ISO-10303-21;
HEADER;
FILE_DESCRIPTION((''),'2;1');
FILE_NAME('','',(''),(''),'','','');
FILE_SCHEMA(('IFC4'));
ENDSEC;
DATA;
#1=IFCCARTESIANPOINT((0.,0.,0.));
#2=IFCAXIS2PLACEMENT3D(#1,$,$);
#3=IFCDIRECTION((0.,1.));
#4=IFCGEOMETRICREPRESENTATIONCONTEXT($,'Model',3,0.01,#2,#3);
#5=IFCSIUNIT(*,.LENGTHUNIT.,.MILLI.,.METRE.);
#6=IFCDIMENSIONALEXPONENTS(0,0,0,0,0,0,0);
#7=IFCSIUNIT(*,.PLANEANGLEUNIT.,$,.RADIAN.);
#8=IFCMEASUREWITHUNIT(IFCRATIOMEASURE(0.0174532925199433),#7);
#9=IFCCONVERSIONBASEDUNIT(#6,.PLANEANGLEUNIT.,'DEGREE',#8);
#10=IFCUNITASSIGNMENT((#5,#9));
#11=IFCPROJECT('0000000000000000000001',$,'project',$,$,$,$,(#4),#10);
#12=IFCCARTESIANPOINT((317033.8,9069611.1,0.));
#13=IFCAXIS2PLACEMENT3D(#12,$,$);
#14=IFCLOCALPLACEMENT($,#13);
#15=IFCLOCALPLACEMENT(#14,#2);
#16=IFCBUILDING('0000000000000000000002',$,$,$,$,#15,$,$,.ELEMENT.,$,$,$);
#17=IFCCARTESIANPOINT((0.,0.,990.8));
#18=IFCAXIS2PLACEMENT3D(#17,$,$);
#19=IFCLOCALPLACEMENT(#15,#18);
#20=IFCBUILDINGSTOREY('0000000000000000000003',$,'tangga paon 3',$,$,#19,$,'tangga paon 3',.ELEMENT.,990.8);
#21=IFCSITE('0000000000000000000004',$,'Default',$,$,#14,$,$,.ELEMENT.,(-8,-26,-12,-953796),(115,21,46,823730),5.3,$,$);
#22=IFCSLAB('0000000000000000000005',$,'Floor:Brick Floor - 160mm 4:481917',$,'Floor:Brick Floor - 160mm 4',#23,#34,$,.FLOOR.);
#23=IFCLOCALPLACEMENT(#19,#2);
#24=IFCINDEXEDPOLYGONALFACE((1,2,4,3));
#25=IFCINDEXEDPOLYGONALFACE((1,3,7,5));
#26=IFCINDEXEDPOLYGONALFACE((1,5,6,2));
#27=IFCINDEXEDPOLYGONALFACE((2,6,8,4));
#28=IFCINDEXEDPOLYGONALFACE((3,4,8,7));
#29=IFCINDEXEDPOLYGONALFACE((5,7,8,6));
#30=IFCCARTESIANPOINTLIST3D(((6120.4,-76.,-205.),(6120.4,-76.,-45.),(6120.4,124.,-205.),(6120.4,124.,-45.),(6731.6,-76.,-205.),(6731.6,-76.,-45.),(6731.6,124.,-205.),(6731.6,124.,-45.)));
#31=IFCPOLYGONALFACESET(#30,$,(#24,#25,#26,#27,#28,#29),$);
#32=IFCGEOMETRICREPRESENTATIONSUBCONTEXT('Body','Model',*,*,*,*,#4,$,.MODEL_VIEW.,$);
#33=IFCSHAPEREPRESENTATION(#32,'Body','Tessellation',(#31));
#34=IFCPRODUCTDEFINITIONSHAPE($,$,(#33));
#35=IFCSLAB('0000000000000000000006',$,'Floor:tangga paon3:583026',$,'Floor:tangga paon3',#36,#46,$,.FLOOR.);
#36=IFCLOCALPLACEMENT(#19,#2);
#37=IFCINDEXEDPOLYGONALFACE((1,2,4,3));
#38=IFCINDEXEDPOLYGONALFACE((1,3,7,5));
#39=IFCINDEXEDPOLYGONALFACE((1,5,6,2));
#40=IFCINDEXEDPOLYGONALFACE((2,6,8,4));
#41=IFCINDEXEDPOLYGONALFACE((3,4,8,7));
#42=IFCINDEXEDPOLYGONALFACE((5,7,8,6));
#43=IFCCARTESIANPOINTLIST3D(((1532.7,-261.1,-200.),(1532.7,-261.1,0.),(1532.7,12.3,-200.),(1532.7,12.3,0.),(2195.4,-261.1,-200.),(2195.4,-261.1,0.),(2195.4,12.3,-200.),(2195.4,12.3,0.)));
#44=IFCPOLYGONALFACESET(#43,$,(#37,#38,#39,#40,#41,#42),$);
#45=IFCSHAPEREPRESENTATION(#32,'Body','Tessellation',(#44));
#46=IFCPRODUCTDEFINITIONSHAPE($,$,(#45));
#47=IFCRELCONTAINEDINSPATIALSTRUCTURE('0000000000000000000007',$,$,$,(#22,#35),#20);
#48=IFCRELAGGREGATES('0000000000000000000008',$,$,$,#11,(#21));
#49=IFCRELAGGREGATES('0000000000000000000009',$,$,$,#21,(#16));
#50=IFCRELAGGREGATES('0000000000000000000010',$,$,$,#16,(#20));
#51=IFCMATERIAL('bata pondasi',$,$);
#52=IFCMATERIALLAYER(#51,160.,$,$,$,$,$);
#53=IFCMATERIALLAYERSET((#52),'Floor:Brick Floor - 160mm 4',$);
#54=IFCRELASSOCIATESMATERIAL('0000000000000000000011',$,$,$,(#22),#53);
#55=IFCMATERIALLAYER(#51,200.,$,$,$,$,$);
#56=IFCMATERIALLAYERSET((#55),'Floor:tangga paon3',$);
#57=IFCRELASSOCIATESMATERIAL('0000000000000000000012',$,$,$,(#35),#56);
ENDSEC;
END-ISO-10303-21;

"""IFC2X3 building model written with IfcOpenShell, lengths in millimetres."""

from ifc_helpers import new_model, entity, si_unit, converted_unit, direction, frame, frame_2d, origin, origin_2d_with_axis, place, context, subcontext, project, spatial, rectangle, extrude, material, layer, layer_set, layer_usage, element, save


model = new_model("IFC2X3")

# Units and contexts
model_context = context("Model", 3, precision=0.01, world=origin(), true_north=direction((0.0, 1.0)))
body_context = subcontext(model_context, "Body", "Model", "MODEL_VIEW")
ifc_project = project(units=[si_unit("LENGTHUNIT", "METRE", prefix="MILLI"), converted_unit("PLANEANGLEUNIT", "DEGREE", entity("IfcRatioMeasure", 0.0174532925199433), si_unit("PLANEANGLEUNIT", "RADIAN"), dimensions=[0, 0, 0, 0, 0, 0, 0])], contexts=[model_context])

# Site, building, storey
site_placement = place(None, frame((317033.8, 9069611.1, 0.0)))
site = spatial("IfcSite", under=ifc_project, at=site_placement, Name="Default", CompositionType="ELEMENT", RefLatitude=(-8, -26, -12, -953796), RefLongitude=(115, 21, 46, 823730), RefElevation=5.3)
building_placement = place(site_placement, origin())
building = spatial("IfcBuilding", under=site, at=building_placement, CompositionType="ELEMENT")
storey_placement = place(building_placement, frame((0.0, 0.0, 990.8)))
storey = spatial("IfcBuildingStorey", under=building, at=storey_placement, Name="tangga paon 3", LongName="tangga paon 3", CompositionType="ELEMENT", Elevation=990.8)

# Slabs
ifc_material = material(Name="bata pondasi")
ifc_layer_1 = layer(ifc_material, 160.0)
ifc_layer_set_1 = layer_set([ifc_layer_1], Name="Floor:Brick Floor - 160mm 4")
ifc_layer_usage_1 = layer_usage(ifc_layer_set_1, "AXIS3", "POSITIVE", 0.0)
slab_1_placement = place(storey_placement, origin())
element("IfcSlab", 1, at=slab_1_placement, inside=storey, material=ifc_layer_usage_1, Name="Floor:Brick Floor - 160mm 4:481917", ObjectType="Floor:Brick Floor - 160mm 4", PredefinedType="FLOOR", context=body_context, shape_type="SweptSolid", body=[
    extrude(rectangle(XDim=200.0, YDim=611.2, at=frame_2d((0.0, 0.0), x_axis=(1.0, 0.0))), frame((6426.0, 24.0, -45.0), z_axis=(0.0, 0.0, -1.0), x_axis=(0.0, 1.0, 0.0)), (0.0, 0.0, 1.0), 160.0),
])
ifc_layer_2 = layer(ifc_material, 200.0)
ifc_layer_set_2 = layer_set([ifc_layer_2], Name="Floor:tangga paon3")
ifc_layer_usage_2 = layer_usage(ifc_layer_set_2, "AXIS3", "POSITIVE", 0.0)
slab_2_placement = place(storey_placement, origin())
element("IfcSlab", 2, at=slab_2_placement, inside=storey, material=ifc_layer_usage_2, Name="Floor:tangga paon3:583026", ObjectType="Floor:tangga paon3", PredefinedType="FLOOR", context=body_context, shape_type="SweptSolid", body=[
    extrude(rectangle(XDim=273.4, YDim=662.6, at=origin_2d_with_axis()), frame((1864.0, -124.4, 0.0), z_axis=(0.0, 0.0, -1.0), x_axis=(0.0, 1.0, 0.0)), (0.0, 0.0, 1.0), 200.0),
])

save(model, "model.ifc")
